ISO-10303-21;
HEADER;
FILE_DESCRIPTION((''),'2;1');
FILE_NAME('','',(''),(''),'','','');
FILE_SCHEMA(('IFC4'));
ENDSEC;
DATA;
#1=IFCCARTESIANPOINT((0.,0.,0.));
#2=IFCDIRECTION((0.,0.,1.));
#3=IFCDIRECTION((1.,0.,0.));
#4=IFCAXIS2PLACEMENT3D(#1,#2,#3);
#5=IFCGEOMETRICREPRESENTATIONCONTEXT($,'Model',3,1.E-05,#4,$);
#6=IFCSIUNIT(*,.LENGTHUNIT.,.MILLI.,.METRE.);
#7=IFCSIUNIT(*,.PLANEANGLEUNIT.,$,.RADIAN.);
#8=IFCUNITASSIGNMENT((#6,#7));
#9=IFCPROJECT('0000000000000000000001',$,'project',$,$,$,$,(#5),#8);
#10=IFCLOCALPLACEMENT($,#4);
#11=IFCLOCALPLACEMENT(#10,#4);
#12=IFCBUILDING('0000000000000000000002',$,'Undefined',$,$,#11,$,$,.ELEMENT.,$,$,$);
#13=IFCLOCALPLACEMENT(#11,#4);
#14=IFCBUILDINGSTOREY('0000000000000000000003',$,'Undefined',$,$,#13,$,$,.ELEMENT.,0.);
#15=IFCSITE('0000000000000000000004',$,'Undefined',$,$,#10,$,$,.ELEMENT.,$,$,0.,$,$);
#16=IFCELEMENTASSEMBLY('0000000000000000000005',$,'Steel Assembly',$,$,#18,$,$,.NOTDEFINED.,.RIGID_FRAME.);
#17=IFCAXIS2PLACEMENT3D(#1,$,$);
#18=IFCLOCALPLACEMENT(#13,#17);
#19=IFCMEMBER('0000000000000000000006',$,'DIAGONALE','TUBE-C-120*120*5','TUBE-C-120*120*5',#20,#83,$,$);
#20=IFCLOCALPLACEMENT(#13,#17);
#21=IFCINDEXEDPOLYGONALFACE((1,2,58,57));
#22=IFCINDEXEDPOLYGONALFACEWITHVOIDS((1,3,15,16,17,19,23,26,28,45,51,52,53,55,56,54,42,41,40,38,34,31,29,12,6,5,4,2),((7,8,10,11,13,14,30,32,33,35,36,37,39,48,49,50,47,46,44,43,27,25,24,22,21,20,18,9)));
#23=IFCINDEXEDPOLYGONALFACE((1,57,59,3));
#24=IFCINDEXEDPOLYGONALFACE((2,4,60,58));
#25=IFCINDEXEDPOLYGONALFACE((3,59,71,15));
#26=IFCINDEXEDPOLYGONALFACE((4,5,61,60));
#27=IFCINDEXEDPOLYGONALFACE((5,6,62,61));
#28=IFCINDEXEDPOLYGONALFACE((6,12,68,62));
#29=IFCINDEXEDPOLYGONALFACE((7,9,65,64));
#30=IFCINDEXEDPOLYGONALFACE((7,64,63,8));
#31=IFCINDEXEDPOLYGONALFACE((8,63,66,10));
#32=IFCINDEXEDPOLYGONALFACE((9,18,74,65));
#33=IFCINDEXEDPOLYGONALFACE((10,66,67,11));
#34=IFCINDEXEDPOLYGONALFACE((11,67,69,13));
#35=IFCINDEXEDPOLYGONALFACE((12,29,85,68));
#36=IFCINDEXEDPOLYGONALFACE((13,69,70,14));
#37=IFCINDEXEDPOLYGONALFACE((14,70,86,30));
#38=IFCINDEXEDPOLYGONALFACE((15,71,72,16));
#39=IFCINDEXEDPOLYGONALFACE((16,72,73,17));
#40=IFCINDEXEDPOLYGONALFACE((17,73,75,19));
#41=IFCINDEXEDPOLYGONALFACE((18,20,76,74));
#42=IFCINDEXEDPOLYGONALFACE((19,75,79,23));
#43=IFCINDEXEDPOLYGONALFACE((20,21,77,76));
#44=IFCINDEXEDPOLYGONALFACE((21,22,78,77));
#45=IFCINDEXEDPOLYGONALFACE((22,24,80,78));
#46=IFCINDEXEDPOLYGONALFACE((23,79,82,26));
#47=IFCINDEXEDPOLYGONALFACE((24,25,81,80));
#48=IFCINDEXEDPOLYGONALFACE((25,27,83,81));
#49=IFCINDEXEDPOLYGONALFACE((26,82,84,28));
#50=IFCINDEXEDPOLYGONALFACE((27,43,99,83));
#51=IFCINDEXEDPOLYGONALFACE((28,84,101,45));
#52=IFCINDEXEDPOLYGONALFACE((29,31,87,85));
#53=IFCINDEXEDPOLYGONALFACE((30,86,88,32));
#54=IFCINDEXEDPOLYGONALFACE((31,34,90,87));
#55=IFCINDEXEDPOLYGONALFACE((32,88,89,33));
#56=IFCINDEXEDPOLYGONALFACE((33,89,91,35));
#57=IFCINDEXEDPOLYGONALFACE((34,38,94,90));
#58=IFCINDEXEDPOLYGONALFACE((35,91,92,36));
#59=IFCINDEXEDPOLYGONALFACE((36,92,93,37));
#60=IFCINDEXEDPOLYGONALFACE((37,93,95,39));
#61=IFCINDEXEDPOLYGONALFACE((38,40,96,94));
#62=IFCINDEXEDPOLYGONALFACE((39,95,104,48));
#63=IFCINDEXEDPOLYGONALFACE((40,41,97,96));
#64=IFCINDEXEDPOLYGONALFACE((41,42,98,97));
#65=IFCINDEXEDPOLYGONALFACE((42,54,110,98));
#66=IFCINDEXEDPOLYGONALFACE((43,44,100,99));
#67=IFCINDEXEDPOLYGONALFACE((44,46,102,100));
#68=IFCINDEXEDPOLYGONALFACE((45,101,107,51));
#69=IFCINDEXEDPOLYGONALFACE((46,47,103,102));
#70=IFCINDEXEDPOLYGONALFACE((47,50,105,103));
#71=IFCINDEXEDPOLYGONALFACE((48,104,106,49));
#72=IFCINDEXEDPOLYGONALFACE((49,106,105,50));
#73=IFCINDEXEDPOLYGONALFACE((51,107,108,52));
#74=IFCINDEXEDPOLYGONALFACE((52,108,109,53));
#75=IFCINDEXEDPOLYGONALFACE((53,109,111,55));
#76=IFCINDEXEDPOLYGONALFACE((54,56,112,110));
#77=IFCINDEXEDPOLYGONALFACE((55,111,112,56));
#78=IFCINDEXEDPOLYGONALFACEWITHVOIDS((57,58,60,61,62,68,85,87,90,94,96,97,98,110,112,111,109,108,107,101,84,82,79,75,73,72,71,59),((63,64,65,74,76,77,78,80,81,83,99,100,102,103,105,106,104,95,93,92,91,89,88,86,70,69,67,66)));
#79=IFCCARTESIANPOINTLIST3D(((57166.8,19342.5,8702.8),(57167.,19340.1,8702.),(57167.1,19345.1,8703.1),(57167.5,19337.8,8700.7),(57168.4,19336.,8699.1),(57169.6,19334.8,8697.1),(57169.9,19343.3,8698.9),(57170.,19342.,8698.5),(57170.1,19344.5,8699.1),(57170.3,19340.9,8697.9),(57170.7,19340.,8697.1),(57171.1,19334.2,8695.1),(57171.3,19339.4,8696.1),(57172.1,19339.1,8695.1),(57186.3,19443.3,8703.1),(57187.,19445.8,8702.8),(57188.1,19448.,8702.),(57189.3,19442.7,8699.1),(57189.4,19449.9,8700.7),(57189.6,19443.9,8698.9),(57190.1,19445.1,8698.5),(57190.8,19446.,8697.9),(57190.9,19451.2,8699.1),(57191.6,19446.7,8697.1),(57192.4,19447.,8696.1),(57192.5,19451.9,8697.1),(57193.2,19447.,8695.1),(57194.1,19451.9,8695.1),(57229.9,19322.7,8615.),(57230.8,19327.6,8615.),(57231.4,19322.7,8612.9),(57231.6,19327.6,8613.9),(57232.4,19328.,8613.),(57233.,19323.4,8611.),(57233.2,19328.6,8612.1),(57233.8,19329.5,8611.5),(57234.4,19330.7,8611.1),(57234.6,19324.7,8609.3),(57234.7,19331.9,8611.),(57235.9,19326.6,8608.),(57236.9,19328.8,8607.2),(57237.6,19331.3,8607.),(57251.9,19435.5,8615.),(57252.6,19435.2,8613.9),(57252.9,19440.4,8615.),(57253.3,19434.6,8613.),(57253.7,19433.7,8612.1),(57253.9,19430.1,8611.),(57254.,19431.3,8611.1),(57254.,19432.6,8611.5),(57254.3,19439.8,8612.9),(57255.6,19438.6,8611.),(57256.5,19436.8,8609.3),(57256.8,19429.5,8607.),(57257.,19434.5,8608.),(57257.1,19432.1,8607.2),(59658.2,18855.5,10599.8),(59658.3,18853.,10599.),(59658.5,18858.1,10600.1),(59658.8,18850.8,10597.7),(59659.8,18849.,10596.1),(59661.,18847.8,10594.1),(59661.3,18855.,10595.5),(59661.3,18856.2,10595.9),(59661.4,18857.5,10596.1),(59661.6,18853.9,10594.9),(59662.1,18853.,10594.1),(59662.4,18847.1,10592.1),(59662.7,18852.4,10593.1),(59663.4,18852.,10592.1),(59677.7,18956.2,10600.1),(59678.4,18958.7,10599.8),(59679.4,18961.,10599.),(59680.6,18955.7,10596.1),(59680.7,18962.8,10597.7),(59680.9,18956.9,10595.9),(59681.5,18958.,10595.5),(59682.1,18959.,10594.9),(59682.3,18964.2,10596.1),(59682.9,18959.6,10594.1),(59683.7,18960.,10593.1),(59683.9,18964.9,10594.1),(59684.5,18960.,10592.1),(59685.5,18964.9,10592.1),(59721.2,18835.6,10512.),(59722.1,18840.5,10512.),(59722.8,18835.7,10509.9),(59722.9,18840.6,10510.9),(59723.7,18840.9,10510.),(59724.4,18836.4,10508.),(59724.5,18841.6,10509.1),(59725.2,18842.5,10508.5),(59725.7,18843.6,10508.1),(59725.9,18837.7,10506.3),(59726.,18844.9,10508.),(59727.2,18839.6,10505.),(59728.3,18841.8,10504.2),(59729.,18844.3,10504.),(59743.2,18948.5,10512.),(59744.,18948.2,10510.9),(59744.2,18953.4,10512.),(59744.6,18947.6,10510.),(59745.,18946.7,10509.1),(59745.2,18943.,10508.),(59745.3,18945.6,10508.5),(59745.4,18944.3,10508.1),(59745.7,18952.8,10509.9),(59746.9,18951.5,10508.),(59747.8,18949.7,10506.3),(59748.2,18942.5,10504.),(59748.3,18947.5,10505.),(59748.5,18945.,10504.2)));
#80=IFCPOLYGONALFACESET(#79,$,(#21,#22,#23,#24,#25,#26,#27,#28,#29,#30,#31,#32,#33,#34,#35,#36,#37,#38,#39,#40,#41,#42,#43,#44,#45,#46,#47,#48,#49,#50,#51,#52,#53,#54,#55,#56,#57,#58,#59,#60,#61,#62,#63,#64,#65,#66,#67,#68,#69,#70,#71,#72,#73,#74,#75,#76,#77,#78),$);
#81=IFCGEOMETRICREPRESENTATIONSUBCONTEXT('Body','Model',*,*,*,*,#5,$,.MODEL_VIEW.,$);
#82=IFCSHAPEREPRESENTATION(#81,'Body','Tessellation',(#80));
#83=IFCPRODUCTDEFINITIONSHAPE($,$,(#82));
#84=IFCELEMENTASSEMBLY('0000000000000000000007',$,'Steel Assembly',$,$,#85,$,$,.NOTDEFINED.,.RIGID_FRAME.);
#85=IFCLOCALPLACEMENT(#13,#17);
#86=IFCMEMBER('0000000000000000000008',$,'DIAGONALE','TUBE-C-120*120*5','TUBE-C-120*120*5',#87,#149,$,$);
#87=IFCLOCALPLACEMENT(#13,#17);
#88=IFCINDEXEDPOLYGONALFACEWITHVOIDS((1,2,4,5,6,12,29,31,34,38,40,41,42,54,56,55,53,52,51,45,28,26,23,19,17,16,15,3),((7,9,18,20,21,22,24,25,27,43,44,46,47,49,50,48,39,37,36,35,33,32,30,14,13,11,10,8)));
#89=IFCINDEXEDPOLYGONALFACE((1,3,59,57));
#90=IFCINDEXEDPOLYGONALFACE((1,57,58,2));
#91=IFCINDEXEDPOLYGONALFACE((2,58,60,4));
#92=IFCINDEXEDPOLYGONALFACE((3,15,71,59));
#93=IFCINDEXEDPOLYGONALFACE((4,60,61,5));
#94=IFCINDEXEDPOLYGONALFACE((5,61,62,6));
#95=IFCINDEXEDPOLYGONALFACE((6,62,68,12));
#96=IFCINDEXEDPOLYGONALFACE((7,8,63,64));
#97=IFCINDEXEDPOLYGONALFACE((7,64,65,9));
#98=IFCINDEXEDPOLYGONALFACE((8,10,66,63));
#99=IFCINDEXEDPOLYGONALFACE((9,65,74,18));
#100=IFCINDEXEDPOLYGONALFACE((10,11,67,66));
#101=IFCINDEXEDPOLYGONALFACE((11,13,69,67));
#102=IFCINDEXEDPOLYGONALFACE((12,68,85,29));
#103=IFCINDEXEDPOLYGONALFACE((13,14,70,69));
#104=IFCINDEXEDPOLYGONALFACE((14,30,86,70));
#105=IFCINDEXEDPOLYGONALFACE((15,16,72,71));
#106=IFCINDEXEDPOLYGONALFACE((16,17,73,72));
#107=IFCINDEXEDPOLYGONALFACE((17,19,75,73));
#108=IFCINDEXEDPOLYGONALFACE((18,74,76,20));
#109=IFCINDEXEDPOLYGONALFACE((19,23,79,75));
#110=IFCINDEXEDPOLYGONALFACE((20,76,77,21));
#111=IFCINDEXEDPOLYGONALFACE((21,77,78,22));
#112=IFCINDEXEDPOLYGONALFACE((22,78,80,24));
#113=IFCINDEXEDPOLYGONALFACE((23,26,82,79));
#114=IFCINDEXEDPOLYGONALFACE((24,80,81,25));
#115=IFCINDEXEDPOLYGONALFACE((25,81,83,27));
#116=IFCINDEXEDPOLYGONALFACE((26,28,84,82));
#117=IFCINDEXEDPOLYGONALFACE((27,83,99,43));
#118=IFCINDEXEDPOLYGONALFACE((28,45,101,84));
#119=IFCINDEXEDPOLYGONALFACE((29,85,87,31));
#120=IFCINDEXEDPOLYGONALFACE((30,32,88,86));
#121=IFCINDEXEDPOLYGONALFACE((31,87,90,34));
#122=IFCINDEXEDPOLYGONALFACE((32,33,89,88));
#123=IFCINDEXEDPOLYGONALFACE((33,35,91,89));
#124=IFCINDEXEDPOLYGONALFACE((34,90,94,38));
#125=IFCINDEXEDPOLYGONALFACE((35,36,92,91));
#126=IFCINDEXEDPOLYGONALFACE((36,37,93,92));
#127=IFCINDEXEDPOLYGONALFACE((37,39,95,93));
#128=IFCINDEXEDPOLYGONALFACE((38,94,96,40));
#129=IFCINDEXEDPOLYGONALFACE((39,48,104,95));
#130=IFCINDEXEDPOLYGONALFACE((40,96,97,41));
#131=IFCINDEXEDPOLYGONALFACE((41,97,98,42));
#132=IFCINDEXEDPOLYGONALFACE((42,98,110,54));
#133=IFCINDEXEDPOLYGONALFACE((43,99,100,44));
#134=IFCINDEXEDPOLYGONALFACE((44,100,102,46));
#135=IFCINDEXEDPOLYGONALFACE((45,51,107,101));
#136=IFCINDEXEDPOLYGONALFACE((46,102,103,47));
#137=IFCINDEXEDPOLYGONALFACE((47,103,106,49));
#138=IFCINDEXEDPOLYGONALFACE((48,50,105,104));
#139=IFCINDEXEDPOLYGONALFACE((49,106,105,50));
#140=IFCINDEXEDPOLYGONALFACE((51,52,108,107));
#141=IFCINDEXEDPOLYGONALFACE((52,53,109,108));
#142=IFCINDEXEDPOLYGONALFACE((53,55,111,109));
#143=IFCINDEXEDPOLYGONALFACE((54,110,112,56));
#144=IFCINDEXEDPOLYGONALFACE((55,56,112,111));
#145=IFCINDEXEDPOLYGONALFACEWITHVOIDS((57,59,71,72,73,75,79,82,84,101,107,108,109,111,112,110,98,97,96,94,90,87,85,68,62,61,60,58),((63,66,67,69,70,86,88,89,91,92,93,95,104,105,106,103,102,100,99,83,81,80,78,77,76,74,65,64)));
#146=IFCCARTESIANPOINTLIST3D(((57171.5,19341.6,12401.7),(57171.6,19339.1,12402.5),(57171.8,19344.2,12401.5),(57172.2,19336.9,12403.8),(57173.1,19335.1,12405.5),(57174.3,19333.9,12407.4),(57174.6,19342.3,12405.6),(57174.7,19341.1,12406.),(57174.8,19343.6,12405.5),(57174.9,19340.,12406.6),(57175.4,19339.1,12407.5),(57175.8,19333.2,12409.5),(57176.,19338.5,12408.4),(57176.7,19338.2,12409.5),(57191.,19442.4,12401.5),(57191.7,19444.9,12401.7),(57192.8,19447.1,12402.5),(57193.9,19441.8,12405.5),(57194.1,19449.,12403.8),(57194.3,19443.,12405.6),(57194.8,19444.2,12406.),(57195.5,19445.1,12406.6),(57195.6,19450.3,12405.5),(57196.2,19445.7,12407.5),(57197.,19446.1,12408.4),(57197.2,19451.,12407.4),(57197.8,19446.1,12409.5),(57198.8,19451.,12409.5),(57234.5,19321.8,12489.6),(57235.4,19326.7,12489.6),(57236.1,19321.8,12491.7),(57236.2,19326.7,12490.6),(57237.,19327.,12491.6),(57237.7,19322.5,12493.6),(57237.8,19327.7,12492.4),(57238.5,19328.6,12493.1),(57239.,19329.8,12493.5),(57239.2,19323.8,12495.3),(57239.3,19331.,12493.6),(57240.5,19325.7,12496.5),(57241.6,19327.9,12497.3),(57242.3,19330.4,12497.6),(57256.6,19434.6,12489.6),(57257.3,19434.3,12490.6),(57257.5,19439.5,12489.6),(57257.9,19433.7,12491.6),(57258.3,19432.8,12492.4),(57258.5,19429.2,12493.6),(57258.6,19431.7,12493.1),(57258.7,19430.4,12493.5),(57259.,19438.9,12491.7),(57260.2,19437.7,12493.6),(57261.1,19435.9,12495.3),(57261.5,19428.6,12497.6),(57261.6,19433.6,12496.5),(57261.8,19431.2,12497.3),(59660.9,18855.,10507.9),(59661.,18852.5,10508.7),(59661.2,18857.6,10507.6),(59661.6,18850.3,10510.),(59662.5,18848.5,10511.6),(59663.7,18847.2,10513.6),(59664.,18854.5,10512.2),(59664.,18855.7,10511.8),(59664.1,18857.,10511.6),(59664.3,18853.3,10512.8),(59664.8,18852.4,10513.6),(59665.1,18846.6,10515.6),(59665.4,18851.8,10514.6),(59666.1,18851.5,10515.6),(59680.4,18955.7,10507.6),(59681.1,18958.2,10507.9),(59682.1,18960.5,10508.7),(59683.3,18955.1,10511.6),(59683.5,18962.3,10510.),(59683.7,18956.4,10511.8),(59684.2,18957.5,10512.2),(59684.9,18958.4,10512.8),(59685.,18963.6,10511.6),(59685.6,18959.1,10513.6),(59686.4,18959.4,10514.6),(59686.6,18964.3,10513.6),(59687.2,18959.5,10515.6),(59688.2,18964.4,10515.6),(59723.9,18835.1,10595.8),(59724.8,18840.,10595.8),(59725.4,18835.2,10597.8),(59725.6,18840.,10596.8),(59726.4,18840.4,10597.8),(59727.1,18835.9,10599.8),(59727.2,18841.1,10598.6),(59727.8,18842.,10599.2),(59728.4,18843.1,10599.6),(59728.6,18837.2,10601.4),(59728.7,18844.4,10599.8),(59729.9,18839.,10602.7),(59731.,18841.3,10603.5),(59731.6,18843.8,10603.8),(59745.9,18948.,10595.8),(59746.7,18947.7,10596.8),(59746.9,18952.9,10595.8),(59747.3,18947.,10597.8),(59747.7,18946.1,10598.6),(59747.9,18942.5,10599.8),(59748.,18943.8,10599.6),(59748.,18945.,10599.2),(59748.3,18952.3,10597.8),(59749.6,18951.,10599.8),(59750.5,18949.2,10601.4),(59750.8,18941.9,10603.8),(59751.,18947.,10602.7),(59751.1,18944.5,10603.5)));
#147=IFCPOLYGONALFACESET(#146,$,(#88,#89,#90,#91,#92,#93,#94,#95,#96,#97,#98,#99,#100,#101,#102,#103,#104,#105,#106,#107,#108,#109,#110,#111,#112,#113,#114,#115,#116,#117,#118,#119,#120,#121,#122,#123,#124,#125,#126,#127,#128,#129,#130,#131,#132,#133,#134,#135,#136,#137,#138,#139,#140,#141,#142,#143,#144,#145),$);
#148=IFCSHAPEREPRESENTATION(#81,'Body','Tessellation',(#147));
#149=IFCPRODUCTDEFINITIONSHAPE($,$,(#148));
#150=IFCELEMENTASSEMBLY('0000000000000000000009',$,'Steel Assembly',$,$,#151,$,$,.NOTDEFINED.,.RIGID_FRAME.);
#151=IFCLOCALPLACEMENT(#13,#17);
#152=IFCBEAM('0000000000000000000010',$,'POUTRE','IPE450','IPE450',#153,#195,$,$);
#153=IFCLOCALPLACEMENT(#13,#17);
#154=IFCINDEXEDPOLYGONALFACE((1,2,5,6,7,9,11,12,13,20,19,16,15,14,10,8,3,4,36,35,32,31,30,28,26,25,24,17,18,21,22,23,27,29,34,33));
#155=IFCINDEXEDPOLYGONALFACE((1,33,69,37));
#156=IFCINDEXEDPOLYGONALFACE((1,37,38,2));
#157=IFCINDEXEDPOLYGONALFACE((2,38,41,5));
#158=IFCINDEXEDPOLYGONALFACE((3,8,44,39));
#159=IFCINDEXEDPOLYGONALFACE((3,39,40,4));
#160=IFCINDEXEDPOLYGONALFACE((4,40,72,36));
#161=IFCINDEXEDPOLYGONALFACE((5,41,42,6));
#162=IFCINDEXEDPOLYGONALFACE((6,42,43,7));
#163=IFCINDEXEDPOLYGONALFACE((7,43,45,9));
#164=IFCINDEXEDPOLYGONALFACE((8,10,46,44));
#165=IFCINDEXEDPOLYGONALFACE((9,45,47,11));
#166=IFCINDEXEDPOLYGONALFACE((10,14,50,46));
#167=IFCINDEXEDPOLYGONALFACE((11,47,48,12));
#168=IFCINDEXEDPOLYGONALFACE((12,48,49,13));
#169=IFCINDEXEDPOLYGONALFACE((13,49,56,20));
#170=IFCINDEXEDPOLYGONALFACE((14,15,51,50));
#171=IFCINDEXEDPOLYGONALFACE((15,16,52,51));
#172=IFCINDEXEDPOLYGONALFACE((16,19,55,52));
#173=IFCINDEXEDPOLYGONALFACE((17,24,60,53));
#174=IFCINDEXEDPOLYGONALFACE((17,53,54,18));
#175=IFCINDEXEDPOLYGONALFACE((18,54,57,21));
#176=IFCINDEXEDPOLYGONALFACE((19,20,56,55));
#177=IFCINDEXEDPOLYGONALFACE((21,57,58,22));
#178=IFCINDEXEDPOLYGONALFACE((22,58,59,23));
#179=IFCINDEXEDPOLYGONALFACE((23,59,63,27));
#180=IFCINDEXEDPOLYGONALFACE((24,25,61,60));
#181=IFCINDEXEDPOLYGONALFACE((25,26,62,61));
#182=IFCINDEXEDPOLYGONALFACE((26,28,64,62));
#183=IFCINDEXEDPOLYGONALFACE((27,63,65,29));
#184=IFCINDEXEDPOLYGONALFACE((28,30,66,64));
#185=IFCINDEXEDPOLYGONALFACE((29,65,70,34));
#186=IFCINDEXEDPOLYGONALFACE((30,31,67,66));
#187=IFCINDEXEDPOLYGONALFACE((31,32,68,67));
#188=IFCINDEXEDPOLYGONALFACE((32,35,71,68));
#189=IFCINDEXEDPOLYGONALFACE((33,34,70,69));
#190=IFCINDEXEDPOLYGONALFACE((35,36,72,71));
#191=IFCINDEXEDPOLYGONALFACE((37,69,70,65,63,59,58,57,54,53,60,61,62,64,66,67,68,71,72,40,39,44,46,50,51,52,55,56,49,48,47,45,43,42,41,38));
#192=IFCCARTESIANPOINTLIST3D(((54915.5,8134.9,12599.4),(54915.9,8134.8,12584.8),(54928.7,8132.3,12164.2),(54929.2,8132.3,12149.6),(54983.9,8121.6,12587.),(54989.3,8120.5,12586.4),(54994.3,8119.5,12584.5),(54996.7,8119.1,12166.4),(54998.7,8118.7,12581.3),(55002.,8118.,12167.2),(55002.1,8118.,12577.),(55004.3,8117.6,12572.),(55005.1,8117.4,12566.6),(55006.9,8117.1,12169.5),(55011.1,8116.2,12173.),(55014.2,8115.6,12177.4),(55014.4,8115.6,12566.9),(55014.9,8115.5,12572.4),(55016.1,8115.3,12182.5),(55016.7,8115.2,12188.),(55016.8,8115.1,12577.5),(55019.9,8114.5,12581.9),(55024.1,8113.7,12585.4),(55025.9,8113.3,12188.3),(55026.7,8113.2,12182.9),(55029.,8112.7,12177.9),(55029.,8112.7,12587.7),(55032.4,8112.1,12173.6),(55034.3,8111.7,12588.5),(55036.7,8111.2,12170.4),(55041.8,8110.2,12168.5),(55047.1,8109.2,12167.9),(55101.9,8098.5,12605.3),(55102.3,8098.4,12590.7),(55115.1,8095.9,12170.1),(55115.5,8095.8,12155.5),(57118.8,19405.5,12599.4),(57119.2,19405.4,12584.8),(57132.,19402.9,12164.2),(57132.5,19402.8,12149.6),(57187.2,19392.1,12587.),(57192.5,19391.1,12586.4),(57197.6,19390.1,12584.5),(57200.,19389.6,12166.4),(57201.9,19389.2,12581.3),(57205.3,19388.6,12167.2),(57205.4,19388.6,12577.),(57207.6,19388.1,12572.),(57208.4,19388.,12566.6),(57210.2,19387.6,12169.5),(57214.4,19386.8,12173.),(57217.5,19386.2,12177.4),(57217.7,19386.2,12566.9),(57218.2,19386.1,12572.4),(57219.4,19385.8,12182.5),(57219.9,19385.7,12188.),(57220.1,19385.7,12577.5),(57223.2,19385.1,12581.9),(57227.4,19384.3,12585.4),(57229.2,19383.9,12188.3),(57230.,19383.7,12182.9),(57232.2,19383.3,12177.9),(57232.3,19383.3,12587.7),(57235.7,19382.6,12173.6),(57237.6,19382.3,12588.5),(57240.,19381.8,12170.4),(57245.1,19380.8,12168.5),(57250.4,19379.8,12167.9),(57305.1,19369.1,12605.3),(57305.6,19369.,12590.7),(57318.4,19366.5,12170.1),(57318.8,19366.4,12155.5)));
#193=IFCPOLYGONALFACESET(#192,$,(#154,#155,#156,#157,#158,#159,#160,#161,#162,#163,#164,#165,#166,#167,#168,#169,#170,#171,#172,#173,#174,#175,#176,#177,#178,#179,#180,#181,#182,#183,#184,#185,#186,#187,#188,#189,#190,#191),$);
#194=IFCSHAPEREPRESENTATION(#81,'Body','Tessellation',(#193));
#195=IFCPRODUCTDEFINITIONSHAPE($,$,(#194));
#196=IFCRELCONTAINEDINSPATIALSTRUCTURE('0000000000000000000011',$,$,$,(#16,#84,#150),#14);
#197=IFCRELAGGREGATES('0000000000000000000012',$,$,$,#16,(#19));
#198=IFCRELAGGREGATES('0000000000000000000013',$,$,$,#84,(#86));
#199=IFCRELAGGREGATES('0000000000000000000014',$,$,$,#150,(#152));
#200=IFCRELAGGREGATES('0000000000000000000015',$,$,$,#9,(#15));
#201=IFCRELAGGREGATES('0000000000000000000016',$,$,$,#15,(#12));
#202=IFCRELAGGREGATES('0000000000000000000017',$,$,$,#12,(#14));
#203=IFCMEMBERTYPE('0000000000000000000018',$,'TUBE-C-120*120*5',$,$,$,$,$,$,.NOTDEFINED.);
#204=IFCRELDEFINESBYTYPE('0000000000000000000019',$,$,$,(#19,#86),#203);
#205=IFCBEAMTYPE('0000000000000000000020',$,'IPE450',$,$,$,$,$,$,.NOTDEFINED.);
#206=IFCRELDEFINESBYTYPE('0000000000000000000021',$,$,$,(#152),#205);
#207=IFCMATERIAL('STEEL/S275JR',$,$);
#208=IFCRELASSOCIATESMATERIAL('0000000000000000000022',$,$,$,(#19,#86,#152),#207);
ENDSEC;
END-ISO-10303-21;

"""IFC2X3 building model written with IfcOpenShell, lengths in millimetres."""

from ifc_helpers import new_model, si_unit, frame, origin_with_axes, origin_2d_with_axis, place, context, subcontext, project, spatial, hollow_rectangle, i_section, extrude, material, type_object, element, aggregate, save


model = new_model("IFC2X3")

# Units and contexts
model_context = context("Model", 3, precision=1e-05, world=origin_with_axes())
body_context = subcontext(model_context, "Body", "Model", "MODEL_VIEW")
ifc_project = project(units=[si_unit("LENGTHUNIT", "METRE", prefix="MILLI"), si_unit("PLANEANGLEUNIT", "RADIAN")], contexts=[model_context])

# Site, building, storey
site_placement = place(None, origin_with_axes())
site = spatial("IfcSite", under=ifc_project, at=site_placement, Name="Undefined", CompositionType="ELEMENT", RefElevation=0.0)
building_placement = place(site_placement, origin_with_axes())
building = spatial("IfcBuilding", under=site, at=building_placement, Name="Undefined", CompositionType="ELEMENT")
storey_placement = place(building_placement, origin_with_axes())
storey = spatial("IfcBuildingStorey", under=building, at=storey_placement, Name="Undefined", CompositionType="ELEMENT", Elevation=0.0)

# Element assemblies, members
assembly_1_placement = place(storey_placement, origin_with_axes())
assembly_1 = element("IfcElementAssembly", 1, at=assembly_1_placement, inside=storey, Name="Steel Assembly", AssemblyPlace="NOTDEFINED", PredefinedType="RIGID_FRAME")
ifc_material_1 = material(Name="STEEL/S275JR")
member_type = type_object("IfcMemberType", Name="TUBE-C-120*120*5", PredefinedType="NOTDEFINED")
member_1_placement = place(assembly_1_placement, frame((57212.0, 19387.3, 8655.0), z_axis=(0.587493, -0.11485, -0.801037), x_axis=(0.786156, -0.153687, 0.598614)))
member_1 = element("IfcMember", 2, at=member_1_placement, type_object=member_type, material=ifc_material_1, Name="DIAGONALE", Description="TUBE-C-120*120*5", ObjectType="TUBE-C-120*120*5", context=body_context, shape_type="SweptSolid", body=[
    extrude(hollow_rectangle(XDim=120.0, YDim=120.0, WallThickness=5.0, InnerFilletRadius=5.0, OuterFilletRadius=10.0, at=origin_2d_with_axis()), frame((3169.0, 0.0, 0.0), z_axis=(-1.0, 0.0, 0.0), x_axis=(0.0, -1.0, 0.0)), (0.0, 0.0, 1.0), 3169.0),
])
aggregate(assembly_1, [member_1])
assembly_2_placement = place(storey_placement, origin_with_axes())
assembly_2 = element("IfcElementAssembly", 3, at=assembly_2_placement, inside=storey, Name="Steel Assembly", AssemblyPlace="NOTDEFINED", PredefinedType="RIGID_FRAME")
member_2_placement = place(assembly_2_placement, frame((57216.7, 19386.4, 12449.5), z_axis=(-0.587158, 0.114784, -0.801293), x_axis=(0.786407, -0.153736, -0.598272)))
member_2 = element("IfcMember", 4, at=member_2_placement, type_object=member_type, material=ifc_material_1, Name="DIAGONALE", Description="TUBE-C-120*120*5", ObjectType="TUBE-C-120*120*5", context=body_context, shape_type="SweptSolid", body=[
    extrude(hollow_rectangle(XDim=120.0, YDim=120.0, WallThickness=5.0, InnerFilletRadius=5.0, OuterFilletRadius=10.0, at=origin_2d_with_axis()), frame((3165.5, 0.0, 0.0), z_axis=(-1.0, 0.0, 0.0), x_axis=(0.0, -1.0, 0.0)), (0.0, 0.0, 1.0), 3165.5),
])
aggregate(assembly_2, [member_2])

# Element assembly, beam
assembly_3_placement = place(storey_placement, origin_with_axes())
assembly_3 = element("IfcElementAssembly", 5, at=assembly_3_placement, inside=storey, Name="Steel Assembly", AssemblyPlace="NOTDEFINED", PredefinedType="RIGID_FRAME")
beam_type = type_object("IfcBeamType", Name="IPE450", PredefinedType="NOTDEFINED")
beam_placement = place(assembly_3_placement, frame((57218.8, 19386.0, 12377.4), z_axis=(-0.030408, 0.005945, 0.99952), x_axis=(-0.19186, -0.981422, 0.0)))
beam = element("IfcBeam", 6, at=beam_placement, type_object=beam_type, material=ifc_material_1, Name="POUTRE", Description="IPE450", ObjectType="IPE450", context=body_context, shape_type="SweptSolid", body=[
    extrude(i_section(OverallWidth=190.0, OverallDepth=450.0, WebThickness=9.4, FlangeThickness=14.6, FilletRadius=21.0, at=origin_2d_with_axis()), frame((11483.9, 0.0, 0.0), z_axis=(-1.0, 0.0, 0.0), x_axis=(0.0, -1.0, 0.0)), (0.0, 0.0, 1.0), 11483.9),
])
aggregate(assembly_3, [beam])

save(model, "model.ifc")
